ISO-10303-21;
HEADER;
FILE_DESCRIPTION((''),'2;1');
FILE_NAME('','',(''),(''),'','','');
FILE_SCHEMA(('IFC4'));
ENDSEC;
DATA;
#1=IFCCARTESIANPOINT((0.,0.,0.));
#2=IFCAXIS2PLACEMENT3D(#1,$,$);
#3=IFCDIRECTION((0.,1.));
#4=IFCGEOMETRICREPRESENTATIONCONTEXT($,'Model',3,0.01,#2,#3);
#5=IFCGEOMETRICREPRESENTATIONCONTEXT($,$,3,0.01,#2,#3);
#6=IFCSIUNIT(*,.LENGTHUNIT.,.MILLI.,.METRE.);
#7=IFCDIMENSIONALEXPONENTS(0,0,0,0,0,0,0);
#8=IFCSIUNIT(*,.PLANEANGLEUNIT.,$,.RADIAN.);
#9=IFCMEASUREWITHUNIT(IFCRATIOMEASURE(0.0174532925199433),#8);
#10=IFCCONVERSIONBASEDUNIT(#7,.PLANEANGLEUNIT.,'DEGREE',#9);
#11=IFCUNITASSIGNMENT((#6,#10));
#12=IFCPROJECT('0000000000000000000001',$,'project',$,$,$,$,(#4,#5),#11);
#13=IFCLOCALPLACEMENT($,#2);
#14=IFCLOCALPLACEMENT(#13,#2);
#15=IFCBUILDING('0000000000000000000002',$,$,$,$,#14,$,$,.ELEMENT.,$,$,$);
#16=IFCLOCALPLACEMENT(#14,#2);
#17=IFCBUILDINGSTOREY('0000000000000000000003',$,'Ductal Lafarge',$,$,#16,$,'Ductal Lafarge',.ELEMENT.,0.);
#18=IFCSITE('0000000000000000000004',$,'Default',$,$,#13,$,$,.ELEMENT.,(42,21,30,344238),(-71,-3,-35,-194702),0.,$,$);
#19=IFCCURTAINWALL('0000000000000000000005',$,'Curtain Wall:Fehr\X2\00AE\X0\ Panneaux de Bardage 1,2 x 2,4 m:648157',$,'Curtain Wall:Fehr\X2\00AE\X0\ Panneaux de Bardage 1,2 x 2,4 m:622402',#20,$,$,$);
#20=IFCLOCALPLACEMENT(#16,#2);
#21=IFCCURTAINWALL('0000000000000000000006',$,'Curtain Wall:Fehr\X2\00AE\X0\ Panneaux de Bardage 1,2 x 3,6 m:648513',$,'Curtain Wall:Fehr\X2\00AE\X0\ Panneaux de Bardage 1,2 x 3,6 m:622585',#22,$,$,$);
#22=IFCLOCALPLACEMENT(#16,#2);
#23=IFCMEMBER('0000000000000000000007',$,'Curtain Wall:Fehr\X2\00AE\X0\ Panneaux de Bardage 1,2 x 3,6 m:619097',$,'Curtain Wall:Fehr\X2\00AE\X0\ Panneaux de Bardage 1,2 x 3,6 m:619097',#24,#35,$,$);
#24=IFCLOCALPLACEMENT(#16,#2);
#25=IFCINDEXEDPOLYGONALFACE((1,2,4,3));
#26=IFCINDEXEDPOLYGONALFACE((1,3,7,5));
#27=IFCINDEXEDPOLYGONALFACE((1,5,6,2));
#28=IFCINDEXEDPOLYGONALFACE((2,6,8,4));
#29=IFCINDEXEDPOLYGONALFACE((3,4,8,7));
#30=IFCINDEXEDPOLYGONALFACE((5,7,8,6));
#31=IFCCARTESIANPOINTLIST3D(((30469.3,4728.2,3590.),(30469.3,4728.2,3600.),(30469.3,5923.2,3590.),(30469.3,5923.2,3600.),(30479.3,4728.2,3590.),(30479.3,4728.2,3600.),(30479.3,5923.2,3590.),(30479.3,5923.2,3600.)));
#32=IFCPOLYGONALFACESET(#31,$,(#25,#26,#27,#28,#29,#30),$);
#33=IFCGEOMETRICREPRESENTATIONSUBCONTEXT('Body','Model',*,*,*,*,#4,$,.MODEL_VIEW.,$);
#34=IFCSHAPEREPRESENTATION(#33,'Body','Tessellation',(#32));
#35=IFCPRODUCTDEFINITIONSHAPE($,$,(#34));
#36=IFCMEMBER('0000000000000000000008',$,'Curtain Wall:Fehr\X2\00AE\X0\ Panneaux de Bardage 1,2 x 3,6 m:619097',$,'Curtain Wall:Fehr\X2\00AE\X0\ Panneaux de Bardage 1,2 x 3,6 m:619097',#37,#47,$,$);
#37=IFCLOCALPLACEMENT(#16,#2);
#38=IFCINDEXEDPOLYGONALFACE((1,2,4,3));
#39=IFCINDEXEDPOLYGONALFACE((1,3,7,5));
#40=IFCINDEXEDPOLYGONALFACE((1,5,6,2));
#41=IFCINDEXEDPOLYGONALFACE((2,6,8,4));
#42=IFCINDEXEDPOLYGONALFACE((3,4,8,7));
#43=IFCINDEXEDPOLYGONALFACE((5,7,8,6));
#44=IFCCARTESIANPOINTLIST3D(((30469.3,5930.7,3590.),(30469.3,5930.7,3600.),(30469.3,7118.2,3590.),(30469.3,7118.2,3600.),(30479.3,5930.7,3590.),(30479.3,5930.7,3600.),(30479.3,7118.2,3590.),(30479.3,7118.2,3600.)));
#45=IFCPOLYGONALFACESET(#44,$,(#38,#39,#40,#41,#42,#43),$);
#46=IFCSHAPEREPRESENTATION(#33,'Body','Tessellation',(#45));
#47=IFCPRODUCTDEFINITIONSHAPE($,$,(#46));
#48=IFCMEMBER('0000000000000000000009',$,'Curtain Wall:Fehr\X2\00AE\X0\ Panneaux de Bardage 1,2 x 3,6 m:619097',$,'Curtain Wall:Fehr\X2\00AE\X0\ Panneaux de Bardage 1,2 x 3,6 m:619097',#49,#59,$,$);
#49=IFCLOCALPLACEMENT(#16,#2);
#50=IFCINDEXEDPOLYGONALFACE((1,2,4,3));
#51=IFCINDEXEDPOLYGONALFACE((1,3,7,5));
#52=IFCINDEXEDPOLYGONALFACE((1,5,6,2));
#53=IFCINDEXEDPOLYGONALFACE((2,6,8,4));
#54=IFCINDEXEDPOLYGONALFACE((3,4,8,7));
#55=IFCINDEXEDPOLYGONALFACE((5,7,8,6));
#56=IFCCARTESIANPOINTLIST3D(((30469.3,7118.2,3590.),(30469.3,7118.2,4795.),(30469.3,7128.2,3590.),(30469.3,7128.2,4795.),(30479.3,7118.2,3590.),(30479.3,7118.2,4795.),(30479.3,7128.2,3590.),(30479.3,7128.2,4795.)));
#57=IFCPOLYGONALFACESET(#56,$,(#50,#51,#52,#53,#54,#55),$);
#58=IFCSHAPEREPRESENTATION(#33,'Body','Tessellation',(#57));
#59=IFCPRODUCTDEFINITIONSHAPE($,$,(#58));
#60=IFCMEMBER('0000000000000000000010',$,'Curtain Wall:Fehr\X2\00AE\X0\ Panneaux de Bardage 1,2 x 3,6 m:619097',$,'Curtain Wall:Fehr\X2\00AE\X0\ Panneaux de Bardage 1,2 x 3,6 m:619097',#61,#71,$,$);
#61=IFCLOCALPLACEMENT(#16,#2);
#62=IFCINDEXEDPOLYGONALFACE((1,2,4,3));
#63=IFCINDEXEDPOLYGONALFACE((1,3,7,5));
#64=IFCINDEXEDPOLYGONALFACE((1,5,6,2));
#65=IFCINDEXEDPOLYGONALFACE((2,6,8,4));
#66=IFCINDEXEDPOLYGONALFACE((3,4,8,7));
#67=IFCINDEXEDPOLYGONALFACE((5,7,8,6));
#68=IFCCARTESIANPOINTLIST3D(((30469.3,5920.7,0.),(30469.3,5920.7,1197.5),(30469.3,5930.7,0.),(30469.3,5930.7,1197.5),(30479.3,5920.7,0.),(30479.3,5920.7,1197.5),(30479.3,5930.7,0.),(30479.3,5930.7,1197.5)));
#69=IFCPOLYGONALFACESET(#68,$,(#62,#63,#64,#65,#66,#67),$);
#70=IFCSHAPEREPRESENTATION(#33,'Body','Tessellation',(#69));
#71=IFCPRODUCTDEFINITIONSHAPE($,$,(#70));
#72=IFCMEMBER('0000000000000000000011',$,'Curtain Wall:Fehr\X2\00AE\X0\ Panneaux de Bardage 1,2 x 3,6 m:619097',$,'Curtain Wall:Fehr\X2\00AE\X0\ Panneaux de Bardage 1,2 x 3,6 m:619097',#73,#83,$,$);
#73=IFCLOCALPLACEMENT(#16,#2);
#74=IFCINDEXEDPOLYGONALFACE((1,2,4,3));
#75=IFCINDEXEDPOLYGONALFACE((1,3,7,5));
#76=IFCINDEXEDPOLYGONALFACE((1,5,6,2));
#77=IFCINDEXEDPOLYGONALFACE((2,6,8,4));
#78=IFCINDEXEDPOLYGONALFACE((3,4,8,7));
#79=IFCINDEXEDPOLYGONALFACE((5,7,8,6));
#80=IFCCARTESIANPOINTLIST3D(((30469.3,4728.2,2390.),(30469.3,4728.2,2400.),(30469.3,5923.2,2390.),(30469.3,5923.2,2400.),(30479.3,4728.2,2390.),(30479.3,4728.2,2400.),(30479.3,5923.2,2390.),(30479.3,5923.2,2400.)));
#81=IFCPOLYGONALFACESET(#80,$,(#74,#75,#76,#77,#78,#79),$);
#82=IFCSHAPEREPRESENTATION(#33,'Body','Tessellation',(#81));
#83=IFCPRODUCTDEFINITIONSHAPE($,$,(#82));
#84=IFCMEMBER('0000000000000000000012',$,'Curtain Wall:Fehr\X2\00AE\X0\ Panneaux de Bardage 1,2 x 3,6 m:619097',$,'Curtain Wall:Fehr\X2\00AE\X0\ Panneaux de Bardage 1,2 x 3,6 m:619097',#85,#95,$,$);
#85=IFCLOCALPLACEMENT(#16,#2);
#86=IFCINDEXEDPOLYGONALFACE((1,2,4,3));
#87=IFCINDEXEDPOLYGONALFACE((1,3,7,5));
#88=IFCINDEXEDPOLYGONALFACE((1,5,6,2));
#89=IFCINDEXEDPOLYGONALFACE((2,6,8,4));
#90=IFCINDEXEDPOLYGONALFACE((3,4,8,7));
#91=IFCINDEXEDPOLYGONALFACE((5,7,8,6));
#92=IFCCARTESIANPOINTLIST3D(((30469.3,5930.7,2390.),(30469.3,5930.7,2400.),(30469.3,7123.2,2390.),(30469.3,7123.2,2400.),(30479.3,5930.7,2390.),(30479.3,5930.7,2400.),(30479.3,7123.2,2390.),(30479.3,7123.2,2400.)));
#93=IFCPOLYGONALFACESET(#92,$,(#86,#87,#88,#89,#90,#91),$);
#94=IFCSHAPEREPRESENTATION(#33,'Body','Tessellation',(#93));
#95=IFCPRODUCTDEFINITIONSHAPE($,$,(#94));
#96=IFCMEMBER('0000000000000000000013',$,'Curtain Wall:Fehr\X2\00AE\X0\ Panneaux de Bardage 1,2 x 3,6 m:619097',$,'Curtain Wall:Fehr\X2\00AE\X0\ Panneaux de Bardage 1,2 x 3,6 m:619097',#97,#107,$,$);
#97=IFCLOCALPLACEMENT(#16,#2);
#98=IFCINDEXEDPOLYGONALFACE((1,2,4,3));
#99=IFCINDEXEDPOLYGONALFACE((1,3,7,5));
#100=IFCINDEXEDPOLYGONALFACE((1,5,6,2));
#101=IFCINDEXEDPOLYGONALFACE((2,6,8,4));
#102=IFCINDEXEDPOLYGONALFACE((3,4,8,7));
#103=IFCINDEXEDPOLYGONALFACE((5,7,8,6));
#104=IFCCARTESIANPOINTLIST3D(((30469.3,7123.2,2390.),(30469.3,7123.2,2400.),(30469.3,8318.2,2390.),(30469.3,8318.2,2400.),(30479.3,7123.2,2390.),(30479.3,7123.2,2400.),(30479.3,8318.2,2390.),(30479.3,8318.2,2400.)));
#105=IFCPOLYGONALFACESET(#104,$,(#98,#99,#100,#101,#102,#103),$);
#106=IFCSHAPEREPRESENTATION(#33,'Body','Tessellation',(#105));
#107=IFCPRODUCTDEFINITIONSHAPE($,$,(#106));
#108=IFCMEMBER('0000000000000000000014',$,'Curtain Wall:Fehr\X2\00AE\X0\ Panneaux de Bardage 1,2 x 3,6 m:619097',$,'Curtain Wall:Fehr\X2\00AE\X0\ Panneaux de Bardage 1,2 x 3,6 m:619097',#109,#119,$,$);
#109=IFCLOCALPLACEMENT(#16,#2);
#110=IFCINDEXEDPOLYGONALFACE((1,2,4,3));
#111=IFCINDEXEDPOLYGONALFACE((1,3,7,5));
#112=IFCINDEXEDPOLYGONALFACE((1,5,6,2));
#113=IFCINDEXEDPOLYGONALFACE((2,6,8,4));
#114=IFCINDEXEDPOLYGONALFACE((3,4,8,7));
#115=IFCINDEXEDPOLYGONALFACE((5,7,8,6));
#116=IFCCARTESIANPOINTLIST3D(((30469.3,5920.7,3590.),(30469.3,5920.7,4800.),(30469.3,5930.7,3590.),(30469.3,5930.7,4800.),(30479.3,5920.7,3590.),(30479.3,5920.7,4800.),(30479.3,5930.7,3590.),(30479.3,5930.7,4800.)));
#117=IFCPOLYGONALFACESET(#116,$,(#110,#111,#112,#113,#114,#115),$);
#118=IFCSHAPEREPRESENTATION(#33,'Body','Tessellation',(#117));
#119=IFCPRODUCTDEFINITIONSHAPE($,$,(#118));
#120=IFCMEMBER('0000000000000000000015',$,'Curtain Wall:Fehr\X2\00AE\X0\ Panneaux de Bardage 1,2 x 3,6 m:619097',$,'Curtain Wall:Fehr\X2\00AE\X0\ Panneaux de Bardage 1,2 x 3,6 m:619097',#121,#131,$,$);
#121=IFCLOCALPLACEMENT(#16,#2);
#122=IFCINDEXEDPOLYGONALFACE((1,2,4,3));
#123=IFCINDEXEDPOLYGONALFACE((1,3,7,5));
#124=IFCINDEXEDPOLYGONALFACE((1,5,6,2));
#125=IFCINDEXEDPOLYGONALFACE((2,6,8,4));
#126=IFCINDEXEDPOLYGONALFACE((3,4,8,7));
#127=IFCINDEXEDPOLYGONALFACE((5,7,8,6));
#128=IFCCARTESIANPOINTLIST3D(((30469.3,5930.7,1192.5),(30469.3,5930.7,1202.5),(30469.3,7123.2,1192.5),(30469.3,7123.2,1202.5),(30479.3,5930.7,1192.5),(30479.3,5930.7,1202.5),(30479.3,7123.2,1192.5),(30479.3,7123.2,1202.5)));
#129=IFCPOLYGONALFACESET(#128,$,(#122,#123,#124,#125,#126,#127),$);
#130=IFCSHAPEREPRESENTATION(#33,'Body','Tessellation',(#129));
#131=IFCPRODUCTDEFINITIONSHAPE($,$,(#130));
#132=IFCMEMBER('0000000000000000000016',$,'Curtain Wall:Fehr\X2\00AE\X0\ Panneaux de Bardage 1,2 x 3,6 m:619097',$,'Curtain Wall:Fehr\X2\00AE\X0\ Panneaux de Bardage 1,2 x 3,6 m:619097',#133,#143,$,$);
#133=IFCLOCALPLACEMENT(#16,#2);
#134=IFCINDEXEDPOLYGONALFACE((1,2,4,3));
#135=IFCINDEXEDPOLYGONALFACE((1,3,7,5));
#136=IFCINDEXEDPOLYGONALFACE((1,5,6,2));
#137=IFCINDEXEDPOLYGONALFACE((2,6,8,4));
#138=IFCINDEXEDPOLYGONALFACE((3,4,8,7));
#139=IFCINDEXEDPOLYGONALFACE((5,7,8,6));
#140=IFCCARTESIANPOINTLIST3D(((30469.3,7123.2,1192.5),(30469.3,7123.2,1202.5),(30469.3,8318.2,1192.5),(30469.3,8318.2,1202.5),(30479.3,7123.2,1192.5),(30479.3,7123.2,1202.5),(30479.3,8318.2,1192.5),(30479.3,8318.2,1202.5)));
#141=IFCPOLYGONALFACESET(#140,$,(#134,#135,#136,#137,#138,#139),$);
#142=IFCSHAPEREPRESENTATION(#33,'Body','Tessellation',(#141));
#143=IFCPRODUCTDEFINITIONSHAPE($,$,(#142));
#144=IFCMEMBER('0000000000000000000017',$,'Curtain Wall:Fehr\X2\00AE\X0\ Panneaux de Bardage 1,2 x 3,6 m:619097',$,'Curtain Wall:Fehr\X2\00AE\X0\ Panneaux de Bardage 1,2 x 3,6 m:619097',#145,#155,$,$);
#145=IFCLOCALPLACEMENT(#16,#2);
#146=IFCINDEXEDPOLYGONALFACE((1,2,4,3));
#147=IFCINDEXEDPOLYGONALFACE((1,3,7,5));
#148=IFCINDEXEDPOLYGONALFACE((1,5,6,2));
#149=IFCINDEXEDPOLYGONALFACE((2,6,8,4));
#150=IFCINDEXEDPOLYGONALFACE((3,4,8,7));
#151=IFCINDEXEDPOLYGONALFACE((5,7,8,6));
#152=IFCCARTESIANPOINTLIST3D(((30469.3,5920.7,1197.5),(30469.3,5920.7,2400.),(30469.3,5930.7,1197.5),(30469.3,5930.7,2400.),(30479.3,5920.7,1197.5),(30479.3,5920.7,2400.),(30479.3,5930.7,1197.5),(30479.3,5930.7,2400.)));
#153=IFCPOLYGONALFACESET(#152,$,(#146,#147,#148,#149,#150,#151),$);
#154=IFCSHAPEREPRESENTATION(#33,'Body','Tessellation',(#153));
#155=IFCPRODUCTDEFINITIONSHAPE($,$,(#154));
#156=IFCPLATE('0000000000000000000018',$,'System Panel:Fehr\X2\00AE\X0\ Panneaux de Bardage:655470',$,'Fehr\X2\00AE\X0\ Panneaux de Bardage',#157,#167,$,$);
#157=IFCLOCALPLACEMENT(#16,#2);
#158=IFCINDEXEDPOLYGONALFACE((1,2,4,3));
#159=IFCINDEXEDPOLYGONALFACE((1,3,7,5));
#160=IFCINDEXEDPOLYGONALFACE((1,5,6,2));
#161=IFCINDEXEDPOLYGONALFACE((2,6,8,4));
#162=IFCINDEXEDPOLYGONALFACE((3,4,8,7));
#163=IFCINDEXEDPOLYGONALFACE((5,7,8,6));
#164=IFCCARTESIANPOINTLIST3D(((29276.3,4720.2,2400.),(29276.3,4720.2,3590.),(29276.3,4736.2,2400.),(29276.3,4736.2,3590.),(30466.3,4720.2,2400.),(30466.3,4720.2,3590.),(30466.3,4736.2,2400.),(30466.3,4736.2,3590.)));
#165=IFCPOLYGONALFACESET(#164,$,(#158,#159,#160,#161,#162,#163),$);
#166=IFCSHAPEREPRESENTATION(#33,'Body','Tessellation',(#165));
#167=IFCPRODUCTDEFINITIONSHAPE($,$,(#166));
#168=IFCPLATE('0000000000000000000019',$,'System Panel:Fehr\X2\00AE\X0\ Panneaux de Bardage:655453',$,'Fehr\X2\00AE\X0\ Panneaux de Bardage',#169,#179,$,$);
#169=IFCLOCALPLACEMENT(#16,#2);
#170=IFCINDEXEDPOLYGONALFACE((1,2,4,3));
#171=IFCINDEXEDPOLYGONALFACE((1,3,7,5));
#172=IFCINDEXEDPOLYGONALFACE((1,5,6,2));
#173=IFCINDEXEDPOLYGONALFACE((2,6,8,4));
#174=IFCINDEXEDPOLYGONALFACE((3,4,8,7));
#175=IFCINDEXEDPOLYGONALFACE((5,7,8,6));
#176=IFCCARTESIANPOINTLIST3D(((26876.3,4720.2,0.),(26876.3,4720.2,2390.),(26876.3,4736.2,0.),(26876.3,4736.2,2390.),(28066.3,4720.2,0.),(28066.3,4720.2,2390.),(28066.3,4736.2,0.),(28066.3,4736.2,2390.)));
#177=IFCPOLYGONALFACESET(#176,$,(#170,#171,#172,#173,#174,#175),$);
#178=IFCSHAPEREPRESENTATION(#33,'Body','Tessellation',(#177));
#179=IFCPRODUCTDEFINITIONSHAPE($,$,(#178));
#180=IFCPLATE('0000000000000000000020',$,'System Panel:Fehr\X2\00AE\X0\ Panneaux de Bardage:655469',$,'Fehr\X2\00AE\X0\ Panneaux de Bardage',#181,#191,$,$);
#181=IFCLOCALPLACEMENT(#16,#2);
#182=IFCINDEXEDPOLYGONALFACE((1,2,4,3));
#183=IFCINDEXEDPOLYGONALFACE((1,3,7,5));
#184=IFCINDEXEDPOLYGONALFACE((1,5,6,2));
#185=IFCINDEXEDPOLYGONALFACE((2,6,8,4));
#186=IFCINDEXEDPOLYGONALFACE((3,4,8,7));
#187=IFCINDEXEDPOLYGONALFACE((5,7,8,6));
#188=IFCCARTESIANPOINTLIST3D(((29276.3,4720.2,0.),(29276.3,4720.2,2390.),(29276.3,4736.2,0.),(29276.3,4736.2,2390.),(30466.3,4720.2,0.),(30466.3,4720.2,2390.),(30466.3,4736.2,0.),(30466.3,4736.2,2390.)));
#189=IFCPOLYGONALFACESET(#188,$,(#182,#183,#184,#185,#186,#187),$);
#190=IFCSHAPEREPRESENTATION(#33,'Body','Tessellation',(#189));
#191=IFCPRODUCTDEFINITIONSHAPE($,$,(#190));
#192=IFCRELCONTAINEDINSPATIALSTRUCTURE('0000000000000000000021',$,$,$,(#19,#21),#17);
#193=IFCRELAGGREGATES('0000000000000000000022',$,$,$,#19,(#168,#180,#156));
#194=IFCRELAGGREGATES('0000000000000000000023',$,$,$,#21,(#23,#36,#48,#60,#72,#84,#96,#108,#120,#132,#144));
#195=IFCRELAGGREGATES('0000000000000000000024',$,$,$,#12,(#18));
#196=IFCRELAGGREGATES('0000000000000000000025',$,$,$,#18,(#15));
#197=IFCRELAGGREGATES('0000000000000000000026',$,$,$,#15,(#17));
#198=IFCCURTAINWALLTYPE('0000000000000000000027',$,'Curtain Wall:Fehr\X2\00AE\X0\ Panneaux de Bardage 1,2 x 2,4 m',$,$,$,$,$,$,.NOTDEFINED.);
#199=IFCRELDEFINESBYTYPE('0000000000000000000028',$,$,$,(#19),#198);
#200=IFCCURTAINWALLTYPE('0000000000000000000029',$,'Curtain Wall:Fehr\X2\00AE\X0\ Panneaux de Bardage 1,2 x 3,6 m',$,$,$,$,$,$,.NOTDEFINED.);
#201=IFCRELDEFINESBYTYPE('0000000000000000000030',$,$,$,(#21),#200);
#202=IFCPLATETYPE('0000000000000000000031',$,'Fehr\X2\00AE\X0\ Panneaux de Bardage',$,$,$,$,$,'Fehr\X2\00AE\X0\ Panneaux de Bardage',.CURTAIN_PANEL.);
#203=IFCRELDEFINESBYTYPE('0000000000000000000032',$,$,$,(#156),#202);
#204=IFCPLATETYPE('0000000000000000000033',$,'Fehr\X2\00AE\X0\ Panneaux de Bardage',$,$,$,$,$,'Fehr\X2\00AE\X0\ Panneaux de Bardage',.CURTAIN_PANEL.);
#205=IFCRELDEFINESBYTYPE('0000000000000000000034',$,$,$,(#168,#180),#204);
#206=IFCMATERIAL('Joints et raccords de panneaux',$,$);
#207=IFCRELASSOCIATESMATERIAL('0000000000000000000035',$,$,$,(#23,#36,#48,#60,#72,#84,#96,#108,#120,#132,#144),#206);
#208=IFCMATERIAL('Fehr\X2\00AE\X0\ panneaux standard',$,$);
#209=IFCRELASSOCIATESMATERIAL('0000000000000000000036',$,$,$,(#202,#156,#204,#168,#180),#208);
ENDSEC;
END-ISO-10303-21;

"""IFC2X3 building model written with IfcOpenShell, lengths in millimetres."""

from ifc_helpers import new_model, entity, si_unit, converted_unit, direction, frame, frame_2d, origin, origin_2d_with_axis, place, context, subcontext, project, spatial, rectangle, extrude, source, transform, mapped, material, type_object, type_shapes, element, aggregate, save


model = new_model("IFC2X3")

# Units and contexts
model_context = context("Model", 3, precision=0.01, world=origin(), true_north=direction((0.0, 1.0)))
context_of_model = context(None, 3, precision=0.01, world=origin(), true_north=direction((0.0, 1.0)))
body_context = subcontext(model_context, "Body", "Model", "MODEL_VIEW")
ifc_project = project(units=[si_unit("LENGTHUNIT", "METRE", prefix="MILLI"), converted_unit("PLANEANGLEUNIT", "DEGREE", entity("IfcRatioMeasure", 0.0174532925199433), si_unit("PLANEANGLEUNIT", "RADIAN"), dimensions=[0, 0, 0, 0, 0, 0, 0])], contexts=[model_context, context_of_model])

# Site, building, storey
site_placement = place(None, origin())
site = spatial("IfcSite", under=ifc_project, at=site_placement, Name="Default", CompositionType="ELEMENT", RefLatitude=(42, 21, 30, 344238), RefLongitude=(-71, -3, -35, -194702), RefElevation=0.0)
building_placement = place(site_placement, origin())
building = spatial("IfcBuilding", under=site, at=building_placement, CompositionType="ELEMENT")
storey_placement = place(building_placement, origin())
storey = spatial("IfcBuildingStorey", under=building, at=storey_placement, Name="Ductal Lafarge", LongName="Ductal Lafarge", CompositionType="ELEMENT", Elevation=0.0)

# Curtain walls, members
curtain_wall_type_1 = type_object("IfcCurtainWallType", Name="Curtain Wall:Fehr® Panneaux de Bardage 1,2 x 2,4 m", PredefinedType="NOTDEFINED")
curtain_wall_1_placement = place(storey_placement, origin())
curtain_wall_1 = element("IfcCurtainWall", 1, at=curtain_wall_1_placement, inside=storey, type_object=curtain_wall_type_1, Name="Curtain Wall:Fehr® Panneaux de Bardage 1,2 x 2,4 m:648157", ObjectType="Curtain Wall:Fehr® Panneaux de Bardage 1,2 x 2,4 m:622402")
ifc_material_1 = material(Name="Joints et raccords de panneaux")
curtain_wall_type_2 = type_object("IfcCurtainWallType", Name="Curtain Wall:Fehr® Panneaux de Bardage 1,2 x 3,6 m", PredefinedType="NOTDEFINED")
curtain_wall_2_placement = place(storey_placement, origin())
curtain_wall_2 = element("IfcCurtainWall", 2, at=curtain_wall_2_placement, inside=storey, type_object=curtain_wall_type_2, Name="Curtain Wall:Fehr® Panneaux de Bardage 1,2 x 3,6 m:648513", ObjectType="Curtain Wall:Fehr® Panneaux de Bardage 1,2 x 3,6 m:622585")
member_1_placement = place(curtain_wall_2_placement, frame((30469.3, 4728.2, 3590.0)))
member_1 = element("IfcMember", 3, at=member_1_placement, material=ifc_material_1, Name="Curtain Wall:Fehr® Panneaux de Bardage 1,2 x 3,6 m:619097", ObjectType="Curtain Wall:Fehr® Panneaux de Bardage 1,2 x 3,6 m:619097", context=body_context, shape_type="SweptSolid", body=[
    extrude(rectangle(XDim=1195.0, YDim=10.0, at=frame_2d((0.0, 0.0), x_axis=(1.0, 0.0))), frame((5.0, 597.5, 0.0), z_axis=(0.0, 0.0, 1.0), x_axis=(0.0, -1.0, 0.0)), (0.0, 0.0, 1.0), 10.0),
])
member_2_placement = place(curtain_wall_2_placement, frame((30469.3, 5930.7, 3590.0)))
member_2 = element("IfcMember", 4, at=member_2_placement, material=ifc_material_1, Name="Curtain Wall:Fehr® Panneaux de Bardage 1,2 x 3,6 m:619097", ObjectType="Curtain Wall:Fehr® Panneaux de Bardage 1,2 x 3,6 m:619097", context=body_context, shape_type="SweptSolid", body=[
    extrude(rectangle(XDim=1187.5, YDim=10.0, at=frame_2d((0.0, 0.0), x_axis=(1.0, 0.0))), frame((5.0, 593.8, 0.0), z_axis=(0.0, 0.0, 1.0), x_axis=(0.0, -1.0, 0.0)), (0.0, 0.0, 1.0), 10.0),
])
member_3_placement = place(curtain_wall_2_placement, frame((30469.3, 7118.2, 3590.0)))
member_3 = element("IfcMember", 5, at=member_3_placement, material=ifc_material_1, Name="Curtain Wall:Fehr® Panneaux de Bardage 1,2 x 3,6 m:619097", ObjectType="Curtain Wall:Fehr® Panneaux de Bardage 1,2 x 3,6 m:619097", context=body_context, shape_type="SweptSolid", body=[
    extrude(rectangle(XDim=10.0, YDim=10.0, at=frame_2d((0.0, 0.0), x_axis=(1.0, 0.0))), frame((5.0, 5.0, 0.0), z_axis=(0.0, 0.0, 1.0), x_axis=(-1.0, 0.0, 0.0)), (0.0, 0.0, 1.0), 1205.0),
])
member_4_placement = place(curtain_wall_2_placement, frame((30469.3, 5920.7, 0.0)))
member_4 = element("IfcMember", 6, at=member_4_placement, material=ifc_material_1, Name="Curtain Wall:Fehr® Panneaux de Bardage 1,2 x 3,6 m:619097", ObjectType="Curtain Wall:Fehr® Panneaux de Bardage 1,2 x 3,6 m:619097", context=body_context, shape_type="SweptSolid", body=[
    extrude(rectangle(XDim=10.0, YDim=10.0, at=frame_2d((0.0, 0.0), x_axis=(1.0, 0.0))), frame((5.0, 5.0, 0.0), z_axis=(0.0, 0.0, 1.0), x_axis=(-1.0, 0.0, 0.0)), (0.0, 0.0, 1.0), 1197.5),
])
member_5_placement = place(curtain_wall_2_placement, frame((30469.3, 4728.2, 2390.0)))
member_5 = element("IfcMember", 7, at=member_5_placement, material=ifc_material_1, Name="Curtain Wall:Fehr® Panneaux de Bardage 1,2 x 3,6 m:619097", ObjectType="Curtain Wall:Fehr® Panneaux de Bardage 1,2 x 3,6 m:619097", context=body_context, shape_type="SweptSolid", body=[
    extrude(rectangle(XDim=1195.0, YDim=10.0, at=frame_2d((0.0, 0.0), x_axis=(1.0, 0.0))), frame((5.0, 597.5, 0.0), z_axis=(0.0, 0.0, 1.0), x_axis=(0.0, -1.0, 0.0)), (0.0, 0.0, 1.0), 10.0),
])
member_6_placement = place(curtain_wall_2_placement, frame((30469.3, 5930.7, 2390.0)))
member_6 = element("IfcMember", 8, at=member_6_placement, material=ifc_material_1, Name="Curtain Wall:Fehr® Panneaux de Bardage 1,2 x 3,6 m:619097", ObjectType="Curtain Wall:Fehr® Panneaux de Bardage 1,2 x 3,6 m:619097", context=body_context, shape_type="SweptSolid", body=[
    extrude(rectangle(XDim=1192.5, YDim=10.0, at=frame_2d((0.0, 0.0), x_axis=(1.0, 0.0))), frame((5.0, 596.2, 0.0), z_axis=(0.0, 0.0, 1.0), x_axis=(0.0, -1.0, 0.0)), (0.0, 0.0, 1.0), 10.0),
])
member_7_placement = place(curtain_wall_2_placement, frame((30469.3, 7123.2, 2390.0)))
member_7 = element("IfcMember", 9, at=member_7_placement, material=ifc_material_1, Name="Curtain Wall:Fehr® Panneaux de Bardage 1,2 x 3,6 m:619097", ObjectType="Curtain Wall:Fehr® Panneaux de Bardage 1,2 x 3,6 m:619097", context=body_context, shape_type="SweptSolid", body=[
    extrude(rectangle(XDim=1195.0, YDim=10.0, at=frame_2d((0.0, 0.0), x_axis=(1.0, 0.0))), frame((5.0, 597.5, 0.0), z_axis=(0.0, 0.0, 1.0), x_axis=(0.0, -1.0, 0.0)), (0.0, 0.0, 1.0), 10.0),
])
member_8_placement = place(curtain_wall_2_placement, frame((30469.3, 5920.7, 3590.0)))
member_8 = element("IfcMember", 10, at=member_8_placement, material=ifc_material_1, Name="Curtain Wall:Fehr® Panneaux de Bardage 1,2 x 3,6 m:619097", ObjectType="Curtain Wall:Fehr® Panneaux de Bardage 1,2 x 3,6 m:619097", context=body_context, shape_type="SweptSolid", body=[
    extrude(rectangle(XDim=10.0, YDim=10.0, at=frame_2d((0.0, 0.0), x_axis=(1.0, 0.0))), frame((5.0, 5.0, 0.0), z_axis=(0.0, 0.0, 1.0), x_axis=(-1.0, 0.0, 0.0)), (0.0, 0.0, 1.0), 1210.0),
])
member_9_placement = place(curtain_wall_2_placement, frame((30469.3, 5930.7, 1192.5)))
member_9 = element("IfcMember", 11, at=member_9_placement, material=ifc_material_1, Name="Curtain Wall:Fehr® Panneaux de Bardage 1,2 x 3,6 m:619097", ObjectType="Curtain Wall:Fehr® Panneaux de Bardage 1,2 x 3,6 m:619097", context=body_context, shape_type="SweptSolid", body=[
    extrude(rectangle(XDim=1192.5, YDim=10.0, at=frame_2d((0.0, 0.0), x_axis=(1.0, 0.0))), frame((5.0, 596.2, 0.0), z_axis=(0.0, 0.0, 1.0), x_axis=(0.0, -1.0, 0.0)), (0.0, 0.0, 1.0), 10.0),
])
member_10_placement = place(curtain_wall_2_placement, frame((30469.3, 7123.2, 1192.5)))
member_10 = element("IfcMember", 12, at=member_10_placement, material=ifc_material_1, Name="Curtain Wall:Fehr® Panneaux de Bardage 1,2 x 3,6 m:619097", ObjectType="Curtain Wall:Fehr® Panneaux de Bardage 1,2 x 3,6 m:619097", context=body_context, shape_type="SweptSolid", body=[
    extrude(rectangle(XDim=1195.0, YDim=10.0, at=frame_2d((0.0, 0.0), x_axis=(1.0, 0.0))), frame((5.0, 597.5, 0.0), z_axis=(0.0, 0.0, 1.0), x_axis=(0.0, -1.0, 0.0)), (0.0, 0.0, 1.0), 10.0),
])
member_11_placement = place(curtain_wall_2_placement, frame((30469.3, 5920.7, 1197.5)))
member_11 = element("IfcMember", 13, at=member_11_placement, material=ifc_material_1, Name="Curtain Wall:Fehr® Panneaux de Bardage 1,2 x 3,6 m:619097", ObjectType="Curtain Wall:Fehr® Panneaux de Bardage 1,2 x 3,6 m:619097", context=body_context, shape_type="SweptSolid", body=[
    extrude(rectangle(XDim=10.0, YDim=10.0, at=frame_2d((0.0, 0.0), x_axis=(1.0, 0.0))), frame((5.0, 5.0, 0.0), z_axis=(0.0, 0.0, 1.0), x_axis=(-1.0, 0.0, 0.0)), (0.0, 0.0, 1.0), 1202.5),
])

# Plates
ifc_material_2 = material(Name="Fehr® panneaux standard")
plate_type_1 = type_object("IfcPlateType", Name="Fehr® Panneaux de Bardage", ElementType="Fehr® Panneaux de Bardage", PredefinedType="CURTAIN_PANEL", material=ifc_material_2)
shared_shape_1 = source(origin(), body_context, "Body", "SweptSolid", [
    extrude(rectangle(XDim=16.0, YDim=1190.0, at=origin_2d_with_axis()), frame((0.0, 0.0, 0.0), z_axis=(0.0, 0.0, 1.0), x_axis=(0.0, 1.0, 0.0)), (0.0, 0.0, 1.0), 1190.0),
])
type_shapes(plate_type_1, [shared_shape_1])
plate_1_placement = place(curtain_wall_1_placement, frame((29871.3, 4728.2, 2400.0)))
plate_1 = element("IfcPlate", 14, at=plate_1_placement, type_object=plate_type_1, material=ifc_material_2, Name="System Panel:Fehr® Panneaux de Bardage:655470", ObjectType="Fehr® Panneaux de Bardage", context=body_context, shape_type="MappedRepresentation", body=[
    mapped(shared_shape_1, transform((0.0, 0.0, 0.0), scale=1.0)),
])
plate_type_2 = type_object("IfcPlateType", Name="Fehr® Panneaux de Bardage", ElementType="Fehr® Panneaux de Bardage", PredefinedType="CURTAIN_PANEL", material=ifc_material_2)
shared_shape_2 = source(origin(), body_context, "Body", "SweptSolid", [
    extrude(rectangle(XDim=2390.0, YDim=1190.0, at=frame_2d((-0.8, 0.0), x_axis=(1.0, 0.0))), frame((0.0, -8.0, 1195.8), z_axis=(0.0, 1.0, 0.0), x_axis=(0.0, 0.0, 1.0)), (0.0, 0.0, 1.0), 16.0),
])
type_shapes(plate_type_2, [shared_shape_2])
plate_2_placement = place(curtain_wall_1_placement, frame((27471.3, 4728.2, 0.0)))
plate_2 = element("IfcPlate", 15, at=plate_2_placement, type_object=plate_type_2, material=ifc_material_2, Name="System Panel:Fehr® Panneaux de Bardage:655453", ObjectType="Fehr® Panneaux de Bardage", context=body_context, shape_type="MappedRepresentation", body=[
    mapped(shared_shape_2, transform((0.0, 0.0, 0.0), scale=1.0)),
])
plate_3_placement = place(curtain_wall_1_placement, frame((29871.3, 4728.2, 0.0)))
plate_3 = element("IfcPlate", 16, at=plate_3_placement, type_object=plate_type_2, material=ifc_material_2, Name="System Panel:Fehr® Panneaux de Bardage:655469", ObjectType="Fehr® Panneaux de Bardage", context=body_context, shape_type="MappedRepresentation", body=[
    mapped(shared_shape_2, transform((0.0, 0.0, 0.0), scale=1.0)),
])
aggregate(curtain_wall_1, [plate_2, plate_3, plate_1])
aggregate(curtain_wall_2, [member_1, member_2, member_3, member_4, member_5, member_6, member_7, member_8, member_9, member_10, member_11])

save(model, "model.ifc")
